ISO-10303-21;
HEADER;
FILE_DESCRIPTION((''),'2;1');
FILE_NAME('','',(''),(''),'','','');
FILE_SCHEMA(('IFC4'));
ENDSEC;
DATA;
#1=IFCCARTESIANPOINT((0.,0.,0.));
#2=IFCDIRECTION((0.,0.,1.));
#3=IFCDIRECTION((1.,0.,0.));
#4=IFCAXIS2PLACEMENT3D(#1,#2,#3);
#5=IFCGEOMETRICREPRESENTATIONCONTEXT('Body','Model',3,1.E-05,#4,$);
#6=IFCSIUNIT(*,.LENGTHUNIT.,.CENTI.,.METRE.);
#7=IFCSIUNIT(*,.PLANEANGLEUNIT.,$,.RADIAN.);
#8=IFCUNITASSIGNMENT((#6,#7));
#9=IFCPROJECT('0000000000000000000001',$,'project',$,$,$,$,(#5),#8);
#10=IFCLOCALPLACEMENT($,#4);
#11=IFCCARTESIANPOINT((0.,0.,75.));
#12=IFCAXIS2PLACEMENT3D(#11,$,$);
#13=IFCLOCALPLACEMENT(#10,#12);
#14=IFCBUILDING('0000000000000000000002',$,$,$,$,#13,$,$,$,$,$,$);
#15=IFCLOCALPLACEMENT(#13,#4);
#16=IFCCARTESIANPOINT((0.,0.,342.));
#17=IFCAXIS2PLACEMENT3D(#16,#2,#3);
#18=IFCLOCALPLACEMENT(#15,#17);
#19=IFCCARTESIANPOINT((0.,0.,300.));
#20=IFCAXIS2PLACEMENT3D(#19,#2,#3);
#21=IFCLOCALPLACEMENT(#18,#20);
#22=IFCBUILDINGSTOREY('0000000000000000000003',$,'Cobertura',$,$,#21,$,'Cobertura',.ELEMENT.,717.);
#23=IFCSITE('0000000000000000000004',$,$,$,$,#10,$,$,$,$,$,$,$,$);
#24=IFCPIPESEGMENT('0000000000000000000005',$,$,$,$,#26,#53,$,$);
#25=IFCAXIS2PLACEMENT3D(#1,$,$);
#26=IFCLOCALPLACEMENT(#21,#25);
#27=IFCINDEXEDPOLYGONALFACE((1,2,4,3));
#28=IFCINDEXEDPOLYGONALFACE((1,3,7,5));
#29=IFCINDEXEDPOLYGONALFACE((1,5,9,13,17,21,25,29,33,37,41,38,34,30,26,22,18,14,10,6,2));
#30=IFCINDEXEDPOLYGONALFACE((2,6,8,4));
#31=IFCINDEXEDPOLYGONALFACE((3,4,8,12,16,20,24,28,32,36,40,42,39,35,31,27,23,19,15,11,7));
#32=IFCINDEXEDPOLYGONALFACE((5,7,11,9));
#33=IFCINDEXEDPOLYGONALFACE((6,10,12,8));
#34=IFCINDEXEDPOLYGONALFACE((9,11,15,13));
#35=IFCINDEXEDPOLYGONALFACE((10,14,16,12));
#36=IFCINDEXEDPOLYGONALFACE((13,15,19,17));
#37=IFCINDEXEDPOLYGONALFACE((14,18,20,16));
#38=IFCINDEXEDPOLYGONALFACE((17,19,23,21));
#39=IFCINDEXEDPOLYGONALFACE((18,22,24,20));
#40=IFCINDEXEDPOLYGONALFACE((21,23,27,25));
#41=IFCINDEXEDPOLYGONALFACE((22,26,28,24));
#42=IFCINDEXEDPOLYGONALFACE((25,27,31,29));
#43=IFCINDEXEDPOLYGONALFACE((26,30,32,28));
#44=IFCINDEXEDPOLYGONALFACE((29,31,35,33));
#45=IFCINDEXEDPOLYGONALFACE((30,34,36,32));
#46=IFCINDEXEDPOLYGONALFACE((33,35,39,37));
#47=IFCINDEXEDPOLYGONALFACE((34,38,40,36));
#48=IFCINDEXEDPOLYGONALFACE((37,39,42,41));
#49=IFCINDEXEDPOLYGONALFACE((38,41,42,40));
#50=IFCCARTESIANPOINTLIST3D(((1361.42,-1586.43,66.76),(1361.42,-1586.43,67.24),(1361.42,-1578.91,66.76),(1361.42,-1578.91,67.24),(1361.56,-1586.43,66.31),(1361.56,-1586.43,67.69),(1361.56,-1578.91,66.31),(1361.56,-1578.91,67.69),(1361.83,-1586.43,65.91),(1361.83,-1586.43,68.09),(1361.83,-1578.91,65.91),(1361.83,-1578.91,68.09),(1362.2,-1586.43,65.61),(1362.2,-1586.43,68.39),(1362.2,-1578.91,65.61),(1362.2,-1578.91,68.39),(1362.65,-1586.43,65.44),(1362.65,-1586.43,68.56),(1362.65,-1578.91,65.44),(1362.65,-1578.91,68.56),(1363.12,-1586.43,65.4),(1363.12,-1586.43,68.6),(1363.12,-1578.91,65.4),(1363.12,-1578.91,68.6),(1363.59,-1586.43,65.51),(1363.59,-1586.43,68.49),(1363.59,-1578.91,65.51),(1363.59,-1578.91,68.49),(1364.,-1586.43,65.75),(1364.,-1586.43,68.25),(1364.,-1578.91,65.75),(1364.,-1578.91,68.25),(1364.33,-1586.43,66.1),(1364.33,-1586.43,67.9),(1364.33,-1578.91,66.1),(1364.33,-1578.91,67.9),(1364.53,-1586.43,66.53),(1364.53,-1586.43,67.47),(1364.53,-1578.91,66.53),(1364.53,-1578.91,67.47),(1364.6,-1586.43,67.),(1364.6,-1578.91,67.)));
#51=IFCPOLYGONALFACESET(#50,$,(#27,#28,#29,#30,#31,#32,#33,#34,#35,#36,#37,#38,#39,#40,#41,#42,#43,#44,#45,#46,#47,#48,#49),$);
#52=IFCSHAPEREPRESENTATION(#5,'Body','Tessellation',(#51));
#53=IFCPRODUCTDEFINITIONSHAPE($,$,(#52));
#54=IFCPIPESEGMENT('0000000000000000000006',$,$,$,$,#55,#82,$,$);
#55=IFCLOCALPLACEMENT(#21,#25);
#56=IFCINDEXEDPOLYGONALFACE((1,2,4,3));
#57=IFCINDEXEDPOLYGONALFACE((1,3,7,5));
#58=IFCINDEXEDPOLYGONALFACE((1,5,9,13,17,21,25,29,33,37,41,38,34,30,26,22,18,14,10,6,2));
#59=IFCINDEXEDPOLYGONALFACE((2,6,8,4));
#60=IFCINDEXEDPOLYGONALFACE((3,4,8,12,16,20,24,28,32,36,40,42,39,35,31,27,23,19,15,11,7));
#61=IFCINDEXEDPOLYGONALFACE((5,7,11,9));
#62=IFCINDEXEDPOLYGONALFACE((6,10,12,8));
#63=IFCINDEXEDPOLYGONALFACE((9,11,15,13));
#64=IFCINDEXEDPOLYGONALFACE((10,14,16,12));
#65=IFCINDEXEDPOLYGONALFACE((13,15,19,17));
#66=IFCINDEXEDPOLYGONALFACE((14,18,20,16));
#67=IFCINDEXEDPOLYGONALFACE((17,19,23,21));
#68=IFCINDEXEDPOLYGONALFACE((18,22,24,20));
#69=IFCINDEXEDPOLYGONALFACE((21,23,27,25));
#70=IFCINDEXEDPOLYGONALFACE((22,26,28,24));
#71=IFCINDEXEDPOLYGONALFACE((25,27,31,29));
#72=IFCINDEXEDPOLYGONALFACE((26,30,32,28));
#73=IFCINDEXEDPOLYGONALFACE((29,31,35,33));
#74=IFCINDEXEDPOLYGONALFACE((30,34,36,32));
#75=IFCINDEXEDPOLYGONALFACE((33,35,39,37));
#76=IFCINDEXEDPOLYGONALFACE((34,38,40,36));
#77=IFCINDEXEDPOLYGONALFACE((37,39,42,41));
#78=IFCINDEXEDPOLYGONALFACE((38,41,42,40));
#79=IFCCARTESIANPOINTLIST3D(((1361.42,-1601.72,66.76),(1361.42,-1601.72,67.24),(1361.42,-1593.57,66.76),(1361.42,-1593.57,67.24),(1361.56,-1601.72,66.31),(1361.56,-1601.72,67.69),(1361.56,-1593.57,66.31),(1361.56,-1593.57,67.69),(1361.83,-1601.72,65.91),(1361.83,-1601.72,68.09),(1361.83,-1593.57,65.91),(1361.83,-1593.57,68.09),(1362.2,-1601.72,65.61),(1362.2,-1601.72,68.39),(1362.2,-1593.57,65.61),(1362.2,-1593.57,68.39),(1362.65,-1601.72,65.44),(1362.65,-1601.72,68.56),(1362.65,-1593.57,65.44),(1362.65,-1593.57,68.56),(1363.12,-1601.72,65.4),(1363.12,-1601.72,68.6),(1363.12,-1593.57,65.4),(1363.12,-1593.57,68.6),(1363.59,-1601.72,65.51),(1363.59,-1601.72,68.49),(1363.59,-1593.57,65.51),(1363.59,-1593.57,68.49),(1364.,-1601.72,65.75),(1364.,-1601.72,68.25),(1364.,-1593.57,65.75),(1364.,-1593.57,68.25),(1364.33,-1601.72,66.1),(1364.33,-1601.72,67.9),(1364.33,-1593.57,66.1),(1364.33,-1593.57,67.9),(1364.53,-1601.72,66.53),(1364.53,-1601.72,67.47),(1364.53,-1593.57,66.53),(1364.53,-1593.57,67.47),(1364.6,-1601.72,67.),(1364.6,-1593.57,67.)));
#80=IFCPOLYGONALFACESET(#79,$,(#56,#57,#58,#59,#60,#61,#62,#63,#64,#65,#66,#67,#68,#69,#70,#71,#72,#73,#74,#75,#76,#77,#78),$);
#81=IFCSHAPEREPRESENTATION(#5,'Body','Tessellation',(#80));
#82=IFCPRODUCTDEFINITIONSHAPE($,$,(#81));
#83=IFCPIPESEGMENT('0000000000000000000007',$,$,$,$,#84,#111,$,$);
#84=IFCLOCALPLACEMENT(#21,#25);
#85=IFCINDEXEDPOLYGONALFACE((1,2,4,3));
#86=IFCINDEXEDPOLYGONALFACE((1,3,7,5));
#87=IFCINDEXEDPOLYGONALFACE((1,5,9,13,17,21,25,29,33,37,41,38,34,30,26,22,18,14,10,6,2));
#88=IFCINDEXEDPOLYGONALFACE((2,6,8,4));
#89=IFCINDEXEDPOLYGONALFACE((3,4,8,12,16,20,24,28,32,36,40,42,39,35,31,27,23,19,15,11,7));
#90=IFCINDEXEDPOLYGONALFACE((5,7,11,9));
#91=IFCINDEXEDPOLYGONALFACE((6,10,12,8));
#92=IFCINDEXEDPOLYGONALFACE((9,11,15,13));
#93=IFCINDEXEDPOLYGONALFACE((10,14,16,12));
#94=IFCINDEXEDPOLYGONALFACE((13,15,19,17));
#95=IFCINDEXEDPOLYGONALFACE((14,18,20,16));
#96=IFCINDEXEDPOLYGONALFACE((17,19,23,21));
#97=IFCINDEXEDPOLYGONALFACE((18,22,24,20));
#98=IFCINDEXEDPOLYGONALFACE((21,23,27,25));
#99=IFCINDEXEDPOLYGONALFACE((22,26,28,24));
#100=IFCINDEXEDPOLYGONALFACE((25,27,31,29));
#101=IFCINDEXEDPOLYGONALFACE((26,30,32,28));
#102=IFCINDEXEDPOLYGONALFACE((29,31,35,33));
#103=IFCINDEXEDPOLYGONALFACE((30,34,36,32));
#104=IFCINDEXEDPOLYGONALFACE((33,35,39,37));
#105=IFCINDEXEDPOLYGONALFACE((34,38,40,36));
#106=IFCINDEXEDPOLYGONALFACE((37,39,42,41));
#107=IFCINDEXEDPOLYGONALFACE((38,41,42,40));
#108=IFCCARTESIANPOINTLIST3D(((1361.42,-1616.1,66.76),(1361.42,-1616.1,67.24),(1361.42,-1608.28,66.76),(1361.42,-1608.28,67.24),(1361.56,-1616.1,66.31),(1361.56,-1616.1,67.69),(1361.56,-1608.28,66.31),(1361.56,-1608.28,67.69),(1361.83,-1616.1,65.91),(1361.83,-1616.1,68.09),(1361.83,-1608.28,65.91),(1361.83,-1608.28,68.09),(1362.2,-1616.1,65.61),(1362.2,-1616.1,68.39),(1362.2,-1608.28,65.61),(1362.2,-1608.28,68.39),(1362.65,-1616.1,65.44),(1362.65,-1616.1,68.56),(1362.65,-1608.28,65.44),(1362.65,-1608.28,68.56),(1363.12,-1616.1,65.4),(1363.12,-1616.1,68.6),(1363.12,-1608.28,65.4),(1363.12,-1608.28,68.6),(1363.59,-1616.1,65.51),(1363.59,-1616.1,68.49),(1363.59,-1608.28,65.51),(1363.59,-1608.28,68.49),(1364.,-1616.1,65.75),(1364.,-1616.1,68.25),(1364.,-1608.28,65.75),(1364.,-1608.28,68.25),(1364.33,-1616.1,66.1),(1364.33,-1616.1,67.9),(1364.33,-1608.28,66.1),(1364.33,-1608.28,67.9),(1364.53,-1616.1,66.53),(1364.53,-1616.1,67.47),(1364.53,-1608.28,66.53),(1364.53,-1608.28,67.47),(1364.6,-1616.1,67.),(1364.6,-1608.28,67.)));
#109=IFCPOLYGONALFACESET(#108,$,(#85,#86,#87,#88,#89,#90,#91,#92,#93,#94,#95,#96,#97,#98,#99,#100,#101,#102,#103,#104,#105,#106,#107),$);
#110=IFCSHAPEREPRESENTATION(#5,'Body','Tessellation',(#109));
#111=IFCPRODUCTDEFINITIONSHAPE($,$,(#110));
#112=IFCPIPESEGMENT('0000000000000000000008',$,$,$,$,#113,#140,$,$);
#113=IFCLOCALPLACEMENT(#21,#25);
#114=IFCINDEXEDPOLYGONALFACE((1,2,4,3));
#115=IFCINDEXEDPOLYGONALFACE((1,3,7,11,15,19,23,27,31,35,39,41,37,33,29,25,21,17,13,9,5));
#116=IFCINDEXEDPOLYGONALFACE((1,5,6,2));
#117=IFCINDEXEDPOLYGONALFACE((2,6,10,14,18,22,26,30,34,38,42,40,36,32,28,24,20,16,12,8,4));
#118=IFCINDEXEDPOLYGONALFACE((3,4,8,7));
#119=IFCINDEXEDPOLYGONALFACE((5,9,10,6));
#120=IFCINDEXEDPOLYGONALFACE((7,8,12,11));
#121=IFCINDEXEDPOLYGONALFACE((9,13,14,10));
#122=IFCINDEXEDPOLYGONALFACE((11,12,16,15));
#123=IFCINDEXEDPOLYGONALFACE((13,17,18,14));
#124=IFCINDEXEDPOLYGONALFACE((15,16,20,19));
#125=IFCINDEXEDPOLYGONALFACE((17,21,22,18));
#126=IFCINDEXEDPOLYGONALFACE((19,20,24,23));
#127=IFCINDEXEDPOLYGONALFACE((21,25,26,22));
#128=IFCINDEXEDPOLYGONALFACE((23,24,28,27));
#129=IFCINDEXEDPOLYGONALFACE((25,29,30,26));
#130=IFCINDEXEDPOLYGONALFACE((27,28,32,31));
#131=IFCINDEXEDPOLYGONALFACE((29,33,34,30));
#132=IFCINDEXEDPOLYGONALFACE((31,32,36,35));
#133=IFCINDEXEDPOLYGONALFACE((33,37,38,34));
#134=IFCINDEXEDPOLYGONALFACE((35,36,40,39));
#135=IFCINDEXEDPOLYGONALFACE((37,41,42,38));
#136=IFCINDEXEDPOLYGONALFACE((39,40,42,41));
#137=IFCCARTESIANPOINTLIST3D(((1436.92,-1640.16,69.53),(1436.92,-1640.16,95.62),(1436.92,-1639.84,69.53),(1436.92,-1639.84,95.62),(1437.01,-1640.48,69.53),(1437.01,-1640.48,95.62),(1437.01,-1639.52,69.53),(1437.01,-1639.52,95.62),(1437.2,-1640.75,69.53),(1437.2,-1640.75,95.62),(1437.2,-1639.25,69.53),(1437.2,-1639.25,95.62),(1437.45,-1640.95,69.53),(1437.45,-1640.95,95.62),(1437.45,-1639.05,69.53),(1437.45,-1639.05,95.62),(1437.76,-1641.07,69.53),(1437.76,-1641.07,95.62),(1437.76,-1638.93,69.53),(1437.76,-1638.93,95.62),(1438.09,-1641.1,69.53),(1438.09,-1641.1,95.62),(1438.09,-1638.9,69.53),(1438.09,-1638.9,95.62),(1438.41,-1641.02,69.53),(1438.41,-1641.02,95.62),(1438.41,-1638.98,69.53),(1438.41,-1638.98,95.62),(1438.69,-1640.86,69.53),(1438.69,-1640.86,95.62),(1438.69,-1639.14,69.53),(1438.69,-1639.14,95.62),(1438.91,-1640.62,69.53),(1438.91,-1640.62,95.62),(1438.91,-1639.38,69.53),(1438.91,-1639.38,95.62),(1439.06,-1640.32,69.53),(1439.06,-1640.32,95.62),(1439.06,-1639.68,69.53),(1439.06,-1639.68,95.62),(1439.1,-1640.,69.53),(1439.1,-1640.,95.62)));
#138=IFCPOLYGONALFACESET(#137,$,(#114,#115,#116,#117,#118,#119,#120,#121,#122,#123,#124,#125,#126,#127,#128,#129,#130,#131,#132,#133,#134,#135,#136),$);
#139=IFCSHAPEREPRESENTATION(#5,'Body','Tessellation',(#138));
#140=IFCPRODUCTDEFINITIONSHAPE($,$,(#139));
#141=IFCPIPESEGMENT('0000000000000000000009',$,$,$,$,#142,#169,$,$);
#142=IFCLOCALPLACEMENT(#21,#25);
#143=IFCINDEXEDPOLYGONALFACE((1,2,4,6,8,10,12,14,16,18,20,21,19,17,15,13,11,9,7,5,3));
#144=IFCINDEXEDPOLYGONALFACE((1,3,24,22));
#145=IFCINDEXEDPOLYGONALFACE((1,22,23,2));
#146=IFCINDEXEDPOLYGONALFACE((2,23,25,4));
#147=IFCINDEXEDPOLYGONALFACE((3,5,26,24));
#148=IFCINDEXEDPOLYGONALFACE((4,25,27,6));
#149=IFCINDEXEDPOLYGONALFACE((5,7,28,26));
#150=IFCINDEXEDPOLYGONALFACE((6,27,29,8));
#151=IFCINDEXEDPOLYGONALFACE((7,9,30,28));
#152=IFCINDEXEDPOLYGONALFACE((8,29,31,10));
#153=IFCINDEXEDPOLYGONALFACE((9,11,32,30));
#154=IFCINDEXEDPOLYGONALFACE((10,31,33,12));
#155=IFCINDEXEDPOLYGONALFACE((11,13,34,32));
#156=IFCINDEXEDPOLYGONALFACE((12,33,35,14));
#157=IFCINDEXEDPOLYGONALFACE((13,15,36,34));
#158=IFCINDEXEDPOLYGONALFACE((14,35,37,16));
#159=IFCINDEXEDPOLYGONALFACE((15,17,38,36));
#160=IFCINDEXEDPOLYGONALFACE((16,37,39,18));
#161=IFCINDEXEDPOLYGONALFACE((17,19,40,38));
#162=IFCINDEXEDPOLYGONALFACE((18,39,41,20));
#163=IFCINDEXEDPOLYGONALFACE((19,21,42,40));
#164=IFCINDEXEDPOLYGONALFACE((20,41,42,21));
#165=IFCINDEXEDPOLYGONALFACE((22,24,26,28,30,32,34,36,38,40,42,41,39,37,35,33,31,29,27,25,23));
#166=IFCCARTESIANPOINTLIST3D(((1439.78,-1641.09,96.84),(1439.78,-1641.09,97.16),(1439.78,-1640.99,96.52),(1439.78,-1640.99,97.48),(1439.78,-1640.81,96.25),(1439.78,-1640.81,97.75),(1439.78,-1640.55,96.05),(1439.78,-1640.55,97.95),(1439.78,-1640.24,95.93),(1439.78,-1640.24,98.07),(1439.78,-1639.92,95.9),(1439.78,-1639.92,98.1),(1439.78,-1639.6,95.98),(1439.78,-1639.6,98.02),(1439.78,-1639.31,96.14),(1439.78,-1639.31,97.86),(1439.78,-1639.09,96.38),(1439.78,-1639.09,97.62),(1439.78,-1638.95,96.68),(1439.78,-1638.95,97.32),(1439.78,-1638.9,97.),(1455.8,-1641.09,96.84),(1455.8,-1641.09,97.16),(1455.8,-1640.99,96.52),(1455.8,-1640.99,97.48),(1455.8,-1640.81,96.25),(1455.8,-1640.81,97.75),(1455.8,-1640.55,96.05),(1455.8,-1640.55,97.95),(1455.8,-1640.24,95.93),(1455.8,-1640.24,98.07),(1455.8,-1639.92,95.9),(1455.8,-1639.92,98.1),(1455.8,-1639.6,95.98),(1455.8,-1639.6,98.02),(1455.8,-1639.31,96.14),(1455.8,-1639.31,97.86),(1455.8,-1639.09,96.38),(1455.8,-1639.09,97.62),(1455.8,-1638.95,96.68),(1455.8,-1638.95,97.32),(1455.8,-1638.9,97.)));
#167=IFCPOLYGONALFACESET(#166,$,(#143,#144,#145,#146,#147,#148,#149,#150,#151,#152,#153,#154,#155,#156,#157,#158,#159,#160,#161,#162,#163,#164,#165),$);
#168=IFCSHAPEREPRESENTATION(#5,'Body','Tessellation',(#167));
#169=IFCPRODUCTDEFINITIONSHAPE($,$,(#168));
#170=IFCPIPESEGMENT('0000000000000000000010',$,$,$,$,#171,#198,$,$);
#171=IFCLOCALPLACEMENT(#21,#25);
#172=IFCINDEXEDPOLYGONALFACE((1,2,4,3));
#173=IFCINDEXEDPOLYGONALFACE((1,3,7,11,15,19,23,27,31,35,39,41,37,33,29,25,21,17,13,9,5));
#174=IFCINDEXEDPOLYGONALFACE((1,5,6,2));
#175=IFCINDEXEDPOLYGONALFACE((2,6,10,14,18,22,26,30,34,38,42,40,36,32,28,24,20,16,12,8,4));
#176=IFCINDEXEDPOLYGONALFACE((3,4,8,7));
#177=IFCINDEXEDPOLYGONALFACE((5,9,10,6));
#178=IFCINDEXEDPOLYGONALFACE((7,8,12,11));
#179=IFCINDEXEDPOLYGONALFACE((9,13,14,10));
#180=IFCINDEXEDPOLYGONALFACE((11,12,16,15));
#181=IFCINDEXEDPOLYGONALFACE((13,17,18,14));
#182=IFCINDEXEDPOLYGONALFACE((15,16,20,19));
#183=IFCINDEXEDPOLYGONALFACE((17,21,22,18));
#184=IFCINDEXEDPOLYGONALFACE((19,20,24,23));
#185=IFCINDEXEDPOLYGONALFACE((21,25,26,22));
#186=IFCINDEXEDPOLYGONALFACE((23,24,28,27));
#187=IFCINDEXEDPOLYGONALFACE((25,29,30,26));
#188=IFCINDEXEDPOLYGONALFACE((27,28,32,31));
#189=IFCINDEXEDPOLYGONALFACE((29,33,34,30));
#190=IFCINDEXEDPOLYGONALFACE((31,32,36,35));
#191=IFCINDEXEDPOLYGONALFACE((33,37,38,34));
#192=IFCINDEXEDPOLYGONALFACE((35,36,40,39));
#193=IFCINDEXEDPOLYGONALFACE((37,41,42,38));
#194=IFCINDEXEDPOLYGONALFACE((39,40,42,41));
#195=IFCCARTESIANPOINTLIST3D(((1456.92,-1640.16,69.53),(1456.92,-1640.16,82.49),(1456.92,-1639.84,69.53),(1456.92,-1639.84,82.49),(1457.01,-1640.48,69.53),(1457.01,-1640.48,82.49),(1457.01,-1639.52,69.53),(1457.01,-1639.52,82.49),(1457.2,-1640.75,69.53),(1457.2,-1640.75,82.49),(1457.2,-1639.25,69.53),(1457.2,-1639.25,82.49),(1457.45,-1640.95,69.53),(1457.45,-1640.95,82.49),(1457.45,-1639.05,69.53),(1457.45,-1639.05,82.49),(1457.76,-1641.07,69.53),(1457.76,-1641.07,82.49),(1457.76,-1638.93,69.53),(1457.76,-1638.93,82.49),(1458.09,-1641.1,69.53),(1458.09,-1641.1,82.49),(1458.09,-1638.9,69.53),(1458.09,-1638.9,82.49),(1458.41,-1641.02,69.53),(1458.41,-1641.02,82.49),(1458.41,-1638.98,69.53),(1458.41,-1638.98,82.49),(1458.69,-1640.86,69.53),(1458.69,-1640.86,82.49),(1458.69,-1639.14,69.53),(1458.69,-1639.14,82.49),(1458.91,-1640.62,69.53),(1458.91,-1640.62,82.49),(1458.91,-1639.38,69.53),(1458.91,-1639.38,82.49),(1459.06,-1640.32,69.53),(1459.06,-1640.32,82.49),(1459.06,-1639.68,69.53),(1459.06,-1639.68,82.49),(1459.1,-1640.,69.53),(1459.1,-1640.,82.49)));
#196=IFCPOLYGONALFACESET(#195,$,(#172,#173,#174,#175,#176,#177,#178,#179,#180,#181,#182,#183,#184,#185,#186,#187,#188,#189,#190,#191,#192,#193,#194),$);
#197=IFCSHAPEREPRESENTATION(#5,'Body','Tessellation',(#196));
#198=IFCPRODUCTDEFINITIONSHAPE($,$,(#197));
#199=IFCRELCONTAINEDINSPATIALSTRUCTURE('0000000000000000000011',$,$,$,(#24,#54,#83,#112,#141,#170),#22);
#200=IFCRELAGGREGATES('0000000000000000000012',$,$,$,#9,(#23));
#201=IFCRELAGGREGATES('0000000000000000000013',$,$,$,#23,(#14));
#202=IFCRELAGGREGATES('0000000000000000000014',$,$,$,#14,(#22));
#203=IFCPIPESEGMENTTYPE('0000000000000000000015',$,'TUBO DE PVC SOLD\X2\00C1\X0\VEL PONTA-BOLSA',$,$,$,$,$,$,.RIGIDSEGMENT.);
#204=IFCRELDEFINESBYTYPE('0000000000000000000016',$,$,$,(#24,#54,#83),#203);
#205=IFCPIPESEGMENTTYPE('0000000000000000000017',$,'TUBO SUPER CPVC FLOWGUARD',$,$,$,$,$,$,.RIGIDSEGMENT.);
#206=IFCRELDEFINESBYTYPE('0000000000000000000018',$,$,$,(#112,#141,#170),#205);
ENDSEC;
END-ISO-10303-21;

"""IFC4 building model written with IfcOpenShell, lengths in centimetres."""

from ifc_helpers import new_model, si_unit, frame, origin_with_axes, origin_2d_with_axis, place, context, project, spatial, circle, extrude, type_object, element, save


model = new_model("IFC4")

# Units and contexts
model_context = context("Model", 3, precision=1e-05, world=origin_with_axes(), identifier="Body")
ifc_project = project(units=[si_unit("LENGTHUNIT", "METRE", prefix="CENTI"), si_unit("PLANEANGLEUNIT", "RADIAN")], contexts=[model_context])

# Site, building, storey
site_placement = place(None, origin_with_axes())
site = spatial("IfcSite", under=ifc_project, at=site_placement)
building_placement = place(site_placement, frame((0.0, 0.0, 75.0)))
building = spatial("IfcBuilding", under=site, at=building_placement)
placement_1 = place(building_placement, origin_with_axes())
placement_2 = place(placement_1, frame((0.0, 0.0, 342.0), z_axis=(0.0, 0.0, 1.0), x_axis=(1.0, 0.0, 0.0)))
storey_placement = place(placement_2, frame((0.0, 0.0, 300.0), z_axis=(0.0, 0.0, 1.0), x_axis=(1.0, 0.0, 0.0)))
storey = spatial("IfcBuildingStorey", under=building, at=storey_placement, Name="Cobertura", LongName="Cobertura", CompositionType="ELEMENT", Elevation=717.0)

# Pipe segments
pipe_segment_type_1 = type_object("IfcPipeSegmentType", Name="TUBO DE PVC SOLDÁVEL PONTA-BOLSA", PredefinedType="RIGIDSEGMENT")
pipe_segment_1_placement = place(storey_placement, frame((1363.0, -1582.67, 68.6), z_axis=(0.0, 0.0, 1.0), x_axis=(1.0, 0.0, 0.0)))
element("IfcPipeSegment", 1, at=pipe_segment_1_placement, inside=storey, type_object=pipe_segment_type_1, context=model_context, shape_type="SolidModel", body=[
    extrude(circle(Radius=1.6, at=origin_2d_with_axis()), frame((0.0, 3.76, -1.6), z_axis=(0.0, -1.0, 0.0), x_axis=(1.0, 0.0, 0.0)), (0.0, 0.0, 1.0), 7.52),
])
pipe_segment_2_placement = place(storey_placement, frame((1363.0, -1597.64, 68.6), z_axis=(0.0, 0.0, 1.0), x_axis=(1.0, 0.0, 0.0)))
element("IfcPipeSegment", 2, at=pipe_segment_2_placement, inside=storey, type_object=pipe_segment_type_1, context=model_context, shape_type="SolidModel", body=[
    extrude(circle(Radius=1.6, at=origin_2d_with_axis()), frame((0.0, 4.07, -1.6), z_axis=(0.0, -1.0, 0.0), x_axis=(1.0, 0.0, 0.0)), (0.0, 0.0, 1.0), 8.15),
])
pipe_segment_3_placement = place(storey_placement, frame((1363.0, -1612.19, 68.6), z_axis=(0.0, 0.0, 1.0), x_axis=(1.0, 0.0, 0.0)))
element("IfcPipeSegment", 3, at=pipe_segment_3_placement, inside=storey, type_object=pipe_segment_type_1, context=model_context, shape_type="SolidModel", body=[
    extrude(circle(Radius=1.6, at=origin_2d_with_axis()), frame((0.0, 3.91, -1.6), z_axis=(0.0, -1.0, 0.0), x_axis=(1.0, 0.0, 0.0)), (0.0, 0.0, 1.0), 7.82),
])
pipe_segment_type_2 = type_object("IfcPipeSegmentType", Name="TUBO SUPER CPVC FLOWGUARD", PredefinedType="RIGIDSEGMENT")
pipe_segment_4_placement = place(storey_placement, frame((1438.0, -1640.0, 95.62), z_axis=(0.0, 0.0, 1.0), x_axis=(1.0, 0.0, 0.0)))
element("IfcPipeSegment", 4, at=pipe_segment_4_placement, inside=storey, type_object=pipe_segment_type_2, context=model_context, shape_type="SolidModel", body=[
    extrude(circle(Radius=1.1, at=origin_2d_with_axis()), frame((0.0, 0.0, -26.09), z_axis=(0.0, 0.0, 1.0), x_axis=(1.0, 0.0, 0.0)), (0.0, 0.0, 1.0), 26.09),
])
pipe_segment_5_placement = place(storey_placement, frame((1447.79, -1640.0, 98.1), z_axis=(0.0, 0.0, 1.0), x_axis=(1.0, 0.0, 0.0)))
element("IfcPipeSegment", 5, at=pipe_segment_5_placement, inside=storey, type_object=pipe_segment_type_2, context=model_context, shape_type="SolidModel", body=[
    extrude(circle(Radius=1.1, at=origin_2d_with_axis()), frame((-8.01, 0.0, -1.1), z_axis=(1.0, 0.0, 0.0), x_axis=(0.0, 1.0, 0.0)), (0.0, 0.0, 1.0), 16.03),
])
pipe_segment_6_placement = place(storey_placement, frame((1458.0, -1640.0, 82.49), z_axis=(0.0, 0.0, 1.0), x_axis=(1.0, 0.0, 0.0)))
element("IfcPipeSegment", 6, at=pipe_segment_6_placement, inside=storey, type_object=pipe_segment_type_2, context=model_context, shape_type="SolidModel", body=[
    extrude(circle(Radius=1.1, at=origin_2d_with_axis()), frame((0.0, 0.0, -12.96), z_axis=(0.0, 0.0, 1.0), x_axis=(1.0, 0.0, 0.0)), (0.0, 0.0, 1.0), 12.96),
])

save(model, "model.ifc")
